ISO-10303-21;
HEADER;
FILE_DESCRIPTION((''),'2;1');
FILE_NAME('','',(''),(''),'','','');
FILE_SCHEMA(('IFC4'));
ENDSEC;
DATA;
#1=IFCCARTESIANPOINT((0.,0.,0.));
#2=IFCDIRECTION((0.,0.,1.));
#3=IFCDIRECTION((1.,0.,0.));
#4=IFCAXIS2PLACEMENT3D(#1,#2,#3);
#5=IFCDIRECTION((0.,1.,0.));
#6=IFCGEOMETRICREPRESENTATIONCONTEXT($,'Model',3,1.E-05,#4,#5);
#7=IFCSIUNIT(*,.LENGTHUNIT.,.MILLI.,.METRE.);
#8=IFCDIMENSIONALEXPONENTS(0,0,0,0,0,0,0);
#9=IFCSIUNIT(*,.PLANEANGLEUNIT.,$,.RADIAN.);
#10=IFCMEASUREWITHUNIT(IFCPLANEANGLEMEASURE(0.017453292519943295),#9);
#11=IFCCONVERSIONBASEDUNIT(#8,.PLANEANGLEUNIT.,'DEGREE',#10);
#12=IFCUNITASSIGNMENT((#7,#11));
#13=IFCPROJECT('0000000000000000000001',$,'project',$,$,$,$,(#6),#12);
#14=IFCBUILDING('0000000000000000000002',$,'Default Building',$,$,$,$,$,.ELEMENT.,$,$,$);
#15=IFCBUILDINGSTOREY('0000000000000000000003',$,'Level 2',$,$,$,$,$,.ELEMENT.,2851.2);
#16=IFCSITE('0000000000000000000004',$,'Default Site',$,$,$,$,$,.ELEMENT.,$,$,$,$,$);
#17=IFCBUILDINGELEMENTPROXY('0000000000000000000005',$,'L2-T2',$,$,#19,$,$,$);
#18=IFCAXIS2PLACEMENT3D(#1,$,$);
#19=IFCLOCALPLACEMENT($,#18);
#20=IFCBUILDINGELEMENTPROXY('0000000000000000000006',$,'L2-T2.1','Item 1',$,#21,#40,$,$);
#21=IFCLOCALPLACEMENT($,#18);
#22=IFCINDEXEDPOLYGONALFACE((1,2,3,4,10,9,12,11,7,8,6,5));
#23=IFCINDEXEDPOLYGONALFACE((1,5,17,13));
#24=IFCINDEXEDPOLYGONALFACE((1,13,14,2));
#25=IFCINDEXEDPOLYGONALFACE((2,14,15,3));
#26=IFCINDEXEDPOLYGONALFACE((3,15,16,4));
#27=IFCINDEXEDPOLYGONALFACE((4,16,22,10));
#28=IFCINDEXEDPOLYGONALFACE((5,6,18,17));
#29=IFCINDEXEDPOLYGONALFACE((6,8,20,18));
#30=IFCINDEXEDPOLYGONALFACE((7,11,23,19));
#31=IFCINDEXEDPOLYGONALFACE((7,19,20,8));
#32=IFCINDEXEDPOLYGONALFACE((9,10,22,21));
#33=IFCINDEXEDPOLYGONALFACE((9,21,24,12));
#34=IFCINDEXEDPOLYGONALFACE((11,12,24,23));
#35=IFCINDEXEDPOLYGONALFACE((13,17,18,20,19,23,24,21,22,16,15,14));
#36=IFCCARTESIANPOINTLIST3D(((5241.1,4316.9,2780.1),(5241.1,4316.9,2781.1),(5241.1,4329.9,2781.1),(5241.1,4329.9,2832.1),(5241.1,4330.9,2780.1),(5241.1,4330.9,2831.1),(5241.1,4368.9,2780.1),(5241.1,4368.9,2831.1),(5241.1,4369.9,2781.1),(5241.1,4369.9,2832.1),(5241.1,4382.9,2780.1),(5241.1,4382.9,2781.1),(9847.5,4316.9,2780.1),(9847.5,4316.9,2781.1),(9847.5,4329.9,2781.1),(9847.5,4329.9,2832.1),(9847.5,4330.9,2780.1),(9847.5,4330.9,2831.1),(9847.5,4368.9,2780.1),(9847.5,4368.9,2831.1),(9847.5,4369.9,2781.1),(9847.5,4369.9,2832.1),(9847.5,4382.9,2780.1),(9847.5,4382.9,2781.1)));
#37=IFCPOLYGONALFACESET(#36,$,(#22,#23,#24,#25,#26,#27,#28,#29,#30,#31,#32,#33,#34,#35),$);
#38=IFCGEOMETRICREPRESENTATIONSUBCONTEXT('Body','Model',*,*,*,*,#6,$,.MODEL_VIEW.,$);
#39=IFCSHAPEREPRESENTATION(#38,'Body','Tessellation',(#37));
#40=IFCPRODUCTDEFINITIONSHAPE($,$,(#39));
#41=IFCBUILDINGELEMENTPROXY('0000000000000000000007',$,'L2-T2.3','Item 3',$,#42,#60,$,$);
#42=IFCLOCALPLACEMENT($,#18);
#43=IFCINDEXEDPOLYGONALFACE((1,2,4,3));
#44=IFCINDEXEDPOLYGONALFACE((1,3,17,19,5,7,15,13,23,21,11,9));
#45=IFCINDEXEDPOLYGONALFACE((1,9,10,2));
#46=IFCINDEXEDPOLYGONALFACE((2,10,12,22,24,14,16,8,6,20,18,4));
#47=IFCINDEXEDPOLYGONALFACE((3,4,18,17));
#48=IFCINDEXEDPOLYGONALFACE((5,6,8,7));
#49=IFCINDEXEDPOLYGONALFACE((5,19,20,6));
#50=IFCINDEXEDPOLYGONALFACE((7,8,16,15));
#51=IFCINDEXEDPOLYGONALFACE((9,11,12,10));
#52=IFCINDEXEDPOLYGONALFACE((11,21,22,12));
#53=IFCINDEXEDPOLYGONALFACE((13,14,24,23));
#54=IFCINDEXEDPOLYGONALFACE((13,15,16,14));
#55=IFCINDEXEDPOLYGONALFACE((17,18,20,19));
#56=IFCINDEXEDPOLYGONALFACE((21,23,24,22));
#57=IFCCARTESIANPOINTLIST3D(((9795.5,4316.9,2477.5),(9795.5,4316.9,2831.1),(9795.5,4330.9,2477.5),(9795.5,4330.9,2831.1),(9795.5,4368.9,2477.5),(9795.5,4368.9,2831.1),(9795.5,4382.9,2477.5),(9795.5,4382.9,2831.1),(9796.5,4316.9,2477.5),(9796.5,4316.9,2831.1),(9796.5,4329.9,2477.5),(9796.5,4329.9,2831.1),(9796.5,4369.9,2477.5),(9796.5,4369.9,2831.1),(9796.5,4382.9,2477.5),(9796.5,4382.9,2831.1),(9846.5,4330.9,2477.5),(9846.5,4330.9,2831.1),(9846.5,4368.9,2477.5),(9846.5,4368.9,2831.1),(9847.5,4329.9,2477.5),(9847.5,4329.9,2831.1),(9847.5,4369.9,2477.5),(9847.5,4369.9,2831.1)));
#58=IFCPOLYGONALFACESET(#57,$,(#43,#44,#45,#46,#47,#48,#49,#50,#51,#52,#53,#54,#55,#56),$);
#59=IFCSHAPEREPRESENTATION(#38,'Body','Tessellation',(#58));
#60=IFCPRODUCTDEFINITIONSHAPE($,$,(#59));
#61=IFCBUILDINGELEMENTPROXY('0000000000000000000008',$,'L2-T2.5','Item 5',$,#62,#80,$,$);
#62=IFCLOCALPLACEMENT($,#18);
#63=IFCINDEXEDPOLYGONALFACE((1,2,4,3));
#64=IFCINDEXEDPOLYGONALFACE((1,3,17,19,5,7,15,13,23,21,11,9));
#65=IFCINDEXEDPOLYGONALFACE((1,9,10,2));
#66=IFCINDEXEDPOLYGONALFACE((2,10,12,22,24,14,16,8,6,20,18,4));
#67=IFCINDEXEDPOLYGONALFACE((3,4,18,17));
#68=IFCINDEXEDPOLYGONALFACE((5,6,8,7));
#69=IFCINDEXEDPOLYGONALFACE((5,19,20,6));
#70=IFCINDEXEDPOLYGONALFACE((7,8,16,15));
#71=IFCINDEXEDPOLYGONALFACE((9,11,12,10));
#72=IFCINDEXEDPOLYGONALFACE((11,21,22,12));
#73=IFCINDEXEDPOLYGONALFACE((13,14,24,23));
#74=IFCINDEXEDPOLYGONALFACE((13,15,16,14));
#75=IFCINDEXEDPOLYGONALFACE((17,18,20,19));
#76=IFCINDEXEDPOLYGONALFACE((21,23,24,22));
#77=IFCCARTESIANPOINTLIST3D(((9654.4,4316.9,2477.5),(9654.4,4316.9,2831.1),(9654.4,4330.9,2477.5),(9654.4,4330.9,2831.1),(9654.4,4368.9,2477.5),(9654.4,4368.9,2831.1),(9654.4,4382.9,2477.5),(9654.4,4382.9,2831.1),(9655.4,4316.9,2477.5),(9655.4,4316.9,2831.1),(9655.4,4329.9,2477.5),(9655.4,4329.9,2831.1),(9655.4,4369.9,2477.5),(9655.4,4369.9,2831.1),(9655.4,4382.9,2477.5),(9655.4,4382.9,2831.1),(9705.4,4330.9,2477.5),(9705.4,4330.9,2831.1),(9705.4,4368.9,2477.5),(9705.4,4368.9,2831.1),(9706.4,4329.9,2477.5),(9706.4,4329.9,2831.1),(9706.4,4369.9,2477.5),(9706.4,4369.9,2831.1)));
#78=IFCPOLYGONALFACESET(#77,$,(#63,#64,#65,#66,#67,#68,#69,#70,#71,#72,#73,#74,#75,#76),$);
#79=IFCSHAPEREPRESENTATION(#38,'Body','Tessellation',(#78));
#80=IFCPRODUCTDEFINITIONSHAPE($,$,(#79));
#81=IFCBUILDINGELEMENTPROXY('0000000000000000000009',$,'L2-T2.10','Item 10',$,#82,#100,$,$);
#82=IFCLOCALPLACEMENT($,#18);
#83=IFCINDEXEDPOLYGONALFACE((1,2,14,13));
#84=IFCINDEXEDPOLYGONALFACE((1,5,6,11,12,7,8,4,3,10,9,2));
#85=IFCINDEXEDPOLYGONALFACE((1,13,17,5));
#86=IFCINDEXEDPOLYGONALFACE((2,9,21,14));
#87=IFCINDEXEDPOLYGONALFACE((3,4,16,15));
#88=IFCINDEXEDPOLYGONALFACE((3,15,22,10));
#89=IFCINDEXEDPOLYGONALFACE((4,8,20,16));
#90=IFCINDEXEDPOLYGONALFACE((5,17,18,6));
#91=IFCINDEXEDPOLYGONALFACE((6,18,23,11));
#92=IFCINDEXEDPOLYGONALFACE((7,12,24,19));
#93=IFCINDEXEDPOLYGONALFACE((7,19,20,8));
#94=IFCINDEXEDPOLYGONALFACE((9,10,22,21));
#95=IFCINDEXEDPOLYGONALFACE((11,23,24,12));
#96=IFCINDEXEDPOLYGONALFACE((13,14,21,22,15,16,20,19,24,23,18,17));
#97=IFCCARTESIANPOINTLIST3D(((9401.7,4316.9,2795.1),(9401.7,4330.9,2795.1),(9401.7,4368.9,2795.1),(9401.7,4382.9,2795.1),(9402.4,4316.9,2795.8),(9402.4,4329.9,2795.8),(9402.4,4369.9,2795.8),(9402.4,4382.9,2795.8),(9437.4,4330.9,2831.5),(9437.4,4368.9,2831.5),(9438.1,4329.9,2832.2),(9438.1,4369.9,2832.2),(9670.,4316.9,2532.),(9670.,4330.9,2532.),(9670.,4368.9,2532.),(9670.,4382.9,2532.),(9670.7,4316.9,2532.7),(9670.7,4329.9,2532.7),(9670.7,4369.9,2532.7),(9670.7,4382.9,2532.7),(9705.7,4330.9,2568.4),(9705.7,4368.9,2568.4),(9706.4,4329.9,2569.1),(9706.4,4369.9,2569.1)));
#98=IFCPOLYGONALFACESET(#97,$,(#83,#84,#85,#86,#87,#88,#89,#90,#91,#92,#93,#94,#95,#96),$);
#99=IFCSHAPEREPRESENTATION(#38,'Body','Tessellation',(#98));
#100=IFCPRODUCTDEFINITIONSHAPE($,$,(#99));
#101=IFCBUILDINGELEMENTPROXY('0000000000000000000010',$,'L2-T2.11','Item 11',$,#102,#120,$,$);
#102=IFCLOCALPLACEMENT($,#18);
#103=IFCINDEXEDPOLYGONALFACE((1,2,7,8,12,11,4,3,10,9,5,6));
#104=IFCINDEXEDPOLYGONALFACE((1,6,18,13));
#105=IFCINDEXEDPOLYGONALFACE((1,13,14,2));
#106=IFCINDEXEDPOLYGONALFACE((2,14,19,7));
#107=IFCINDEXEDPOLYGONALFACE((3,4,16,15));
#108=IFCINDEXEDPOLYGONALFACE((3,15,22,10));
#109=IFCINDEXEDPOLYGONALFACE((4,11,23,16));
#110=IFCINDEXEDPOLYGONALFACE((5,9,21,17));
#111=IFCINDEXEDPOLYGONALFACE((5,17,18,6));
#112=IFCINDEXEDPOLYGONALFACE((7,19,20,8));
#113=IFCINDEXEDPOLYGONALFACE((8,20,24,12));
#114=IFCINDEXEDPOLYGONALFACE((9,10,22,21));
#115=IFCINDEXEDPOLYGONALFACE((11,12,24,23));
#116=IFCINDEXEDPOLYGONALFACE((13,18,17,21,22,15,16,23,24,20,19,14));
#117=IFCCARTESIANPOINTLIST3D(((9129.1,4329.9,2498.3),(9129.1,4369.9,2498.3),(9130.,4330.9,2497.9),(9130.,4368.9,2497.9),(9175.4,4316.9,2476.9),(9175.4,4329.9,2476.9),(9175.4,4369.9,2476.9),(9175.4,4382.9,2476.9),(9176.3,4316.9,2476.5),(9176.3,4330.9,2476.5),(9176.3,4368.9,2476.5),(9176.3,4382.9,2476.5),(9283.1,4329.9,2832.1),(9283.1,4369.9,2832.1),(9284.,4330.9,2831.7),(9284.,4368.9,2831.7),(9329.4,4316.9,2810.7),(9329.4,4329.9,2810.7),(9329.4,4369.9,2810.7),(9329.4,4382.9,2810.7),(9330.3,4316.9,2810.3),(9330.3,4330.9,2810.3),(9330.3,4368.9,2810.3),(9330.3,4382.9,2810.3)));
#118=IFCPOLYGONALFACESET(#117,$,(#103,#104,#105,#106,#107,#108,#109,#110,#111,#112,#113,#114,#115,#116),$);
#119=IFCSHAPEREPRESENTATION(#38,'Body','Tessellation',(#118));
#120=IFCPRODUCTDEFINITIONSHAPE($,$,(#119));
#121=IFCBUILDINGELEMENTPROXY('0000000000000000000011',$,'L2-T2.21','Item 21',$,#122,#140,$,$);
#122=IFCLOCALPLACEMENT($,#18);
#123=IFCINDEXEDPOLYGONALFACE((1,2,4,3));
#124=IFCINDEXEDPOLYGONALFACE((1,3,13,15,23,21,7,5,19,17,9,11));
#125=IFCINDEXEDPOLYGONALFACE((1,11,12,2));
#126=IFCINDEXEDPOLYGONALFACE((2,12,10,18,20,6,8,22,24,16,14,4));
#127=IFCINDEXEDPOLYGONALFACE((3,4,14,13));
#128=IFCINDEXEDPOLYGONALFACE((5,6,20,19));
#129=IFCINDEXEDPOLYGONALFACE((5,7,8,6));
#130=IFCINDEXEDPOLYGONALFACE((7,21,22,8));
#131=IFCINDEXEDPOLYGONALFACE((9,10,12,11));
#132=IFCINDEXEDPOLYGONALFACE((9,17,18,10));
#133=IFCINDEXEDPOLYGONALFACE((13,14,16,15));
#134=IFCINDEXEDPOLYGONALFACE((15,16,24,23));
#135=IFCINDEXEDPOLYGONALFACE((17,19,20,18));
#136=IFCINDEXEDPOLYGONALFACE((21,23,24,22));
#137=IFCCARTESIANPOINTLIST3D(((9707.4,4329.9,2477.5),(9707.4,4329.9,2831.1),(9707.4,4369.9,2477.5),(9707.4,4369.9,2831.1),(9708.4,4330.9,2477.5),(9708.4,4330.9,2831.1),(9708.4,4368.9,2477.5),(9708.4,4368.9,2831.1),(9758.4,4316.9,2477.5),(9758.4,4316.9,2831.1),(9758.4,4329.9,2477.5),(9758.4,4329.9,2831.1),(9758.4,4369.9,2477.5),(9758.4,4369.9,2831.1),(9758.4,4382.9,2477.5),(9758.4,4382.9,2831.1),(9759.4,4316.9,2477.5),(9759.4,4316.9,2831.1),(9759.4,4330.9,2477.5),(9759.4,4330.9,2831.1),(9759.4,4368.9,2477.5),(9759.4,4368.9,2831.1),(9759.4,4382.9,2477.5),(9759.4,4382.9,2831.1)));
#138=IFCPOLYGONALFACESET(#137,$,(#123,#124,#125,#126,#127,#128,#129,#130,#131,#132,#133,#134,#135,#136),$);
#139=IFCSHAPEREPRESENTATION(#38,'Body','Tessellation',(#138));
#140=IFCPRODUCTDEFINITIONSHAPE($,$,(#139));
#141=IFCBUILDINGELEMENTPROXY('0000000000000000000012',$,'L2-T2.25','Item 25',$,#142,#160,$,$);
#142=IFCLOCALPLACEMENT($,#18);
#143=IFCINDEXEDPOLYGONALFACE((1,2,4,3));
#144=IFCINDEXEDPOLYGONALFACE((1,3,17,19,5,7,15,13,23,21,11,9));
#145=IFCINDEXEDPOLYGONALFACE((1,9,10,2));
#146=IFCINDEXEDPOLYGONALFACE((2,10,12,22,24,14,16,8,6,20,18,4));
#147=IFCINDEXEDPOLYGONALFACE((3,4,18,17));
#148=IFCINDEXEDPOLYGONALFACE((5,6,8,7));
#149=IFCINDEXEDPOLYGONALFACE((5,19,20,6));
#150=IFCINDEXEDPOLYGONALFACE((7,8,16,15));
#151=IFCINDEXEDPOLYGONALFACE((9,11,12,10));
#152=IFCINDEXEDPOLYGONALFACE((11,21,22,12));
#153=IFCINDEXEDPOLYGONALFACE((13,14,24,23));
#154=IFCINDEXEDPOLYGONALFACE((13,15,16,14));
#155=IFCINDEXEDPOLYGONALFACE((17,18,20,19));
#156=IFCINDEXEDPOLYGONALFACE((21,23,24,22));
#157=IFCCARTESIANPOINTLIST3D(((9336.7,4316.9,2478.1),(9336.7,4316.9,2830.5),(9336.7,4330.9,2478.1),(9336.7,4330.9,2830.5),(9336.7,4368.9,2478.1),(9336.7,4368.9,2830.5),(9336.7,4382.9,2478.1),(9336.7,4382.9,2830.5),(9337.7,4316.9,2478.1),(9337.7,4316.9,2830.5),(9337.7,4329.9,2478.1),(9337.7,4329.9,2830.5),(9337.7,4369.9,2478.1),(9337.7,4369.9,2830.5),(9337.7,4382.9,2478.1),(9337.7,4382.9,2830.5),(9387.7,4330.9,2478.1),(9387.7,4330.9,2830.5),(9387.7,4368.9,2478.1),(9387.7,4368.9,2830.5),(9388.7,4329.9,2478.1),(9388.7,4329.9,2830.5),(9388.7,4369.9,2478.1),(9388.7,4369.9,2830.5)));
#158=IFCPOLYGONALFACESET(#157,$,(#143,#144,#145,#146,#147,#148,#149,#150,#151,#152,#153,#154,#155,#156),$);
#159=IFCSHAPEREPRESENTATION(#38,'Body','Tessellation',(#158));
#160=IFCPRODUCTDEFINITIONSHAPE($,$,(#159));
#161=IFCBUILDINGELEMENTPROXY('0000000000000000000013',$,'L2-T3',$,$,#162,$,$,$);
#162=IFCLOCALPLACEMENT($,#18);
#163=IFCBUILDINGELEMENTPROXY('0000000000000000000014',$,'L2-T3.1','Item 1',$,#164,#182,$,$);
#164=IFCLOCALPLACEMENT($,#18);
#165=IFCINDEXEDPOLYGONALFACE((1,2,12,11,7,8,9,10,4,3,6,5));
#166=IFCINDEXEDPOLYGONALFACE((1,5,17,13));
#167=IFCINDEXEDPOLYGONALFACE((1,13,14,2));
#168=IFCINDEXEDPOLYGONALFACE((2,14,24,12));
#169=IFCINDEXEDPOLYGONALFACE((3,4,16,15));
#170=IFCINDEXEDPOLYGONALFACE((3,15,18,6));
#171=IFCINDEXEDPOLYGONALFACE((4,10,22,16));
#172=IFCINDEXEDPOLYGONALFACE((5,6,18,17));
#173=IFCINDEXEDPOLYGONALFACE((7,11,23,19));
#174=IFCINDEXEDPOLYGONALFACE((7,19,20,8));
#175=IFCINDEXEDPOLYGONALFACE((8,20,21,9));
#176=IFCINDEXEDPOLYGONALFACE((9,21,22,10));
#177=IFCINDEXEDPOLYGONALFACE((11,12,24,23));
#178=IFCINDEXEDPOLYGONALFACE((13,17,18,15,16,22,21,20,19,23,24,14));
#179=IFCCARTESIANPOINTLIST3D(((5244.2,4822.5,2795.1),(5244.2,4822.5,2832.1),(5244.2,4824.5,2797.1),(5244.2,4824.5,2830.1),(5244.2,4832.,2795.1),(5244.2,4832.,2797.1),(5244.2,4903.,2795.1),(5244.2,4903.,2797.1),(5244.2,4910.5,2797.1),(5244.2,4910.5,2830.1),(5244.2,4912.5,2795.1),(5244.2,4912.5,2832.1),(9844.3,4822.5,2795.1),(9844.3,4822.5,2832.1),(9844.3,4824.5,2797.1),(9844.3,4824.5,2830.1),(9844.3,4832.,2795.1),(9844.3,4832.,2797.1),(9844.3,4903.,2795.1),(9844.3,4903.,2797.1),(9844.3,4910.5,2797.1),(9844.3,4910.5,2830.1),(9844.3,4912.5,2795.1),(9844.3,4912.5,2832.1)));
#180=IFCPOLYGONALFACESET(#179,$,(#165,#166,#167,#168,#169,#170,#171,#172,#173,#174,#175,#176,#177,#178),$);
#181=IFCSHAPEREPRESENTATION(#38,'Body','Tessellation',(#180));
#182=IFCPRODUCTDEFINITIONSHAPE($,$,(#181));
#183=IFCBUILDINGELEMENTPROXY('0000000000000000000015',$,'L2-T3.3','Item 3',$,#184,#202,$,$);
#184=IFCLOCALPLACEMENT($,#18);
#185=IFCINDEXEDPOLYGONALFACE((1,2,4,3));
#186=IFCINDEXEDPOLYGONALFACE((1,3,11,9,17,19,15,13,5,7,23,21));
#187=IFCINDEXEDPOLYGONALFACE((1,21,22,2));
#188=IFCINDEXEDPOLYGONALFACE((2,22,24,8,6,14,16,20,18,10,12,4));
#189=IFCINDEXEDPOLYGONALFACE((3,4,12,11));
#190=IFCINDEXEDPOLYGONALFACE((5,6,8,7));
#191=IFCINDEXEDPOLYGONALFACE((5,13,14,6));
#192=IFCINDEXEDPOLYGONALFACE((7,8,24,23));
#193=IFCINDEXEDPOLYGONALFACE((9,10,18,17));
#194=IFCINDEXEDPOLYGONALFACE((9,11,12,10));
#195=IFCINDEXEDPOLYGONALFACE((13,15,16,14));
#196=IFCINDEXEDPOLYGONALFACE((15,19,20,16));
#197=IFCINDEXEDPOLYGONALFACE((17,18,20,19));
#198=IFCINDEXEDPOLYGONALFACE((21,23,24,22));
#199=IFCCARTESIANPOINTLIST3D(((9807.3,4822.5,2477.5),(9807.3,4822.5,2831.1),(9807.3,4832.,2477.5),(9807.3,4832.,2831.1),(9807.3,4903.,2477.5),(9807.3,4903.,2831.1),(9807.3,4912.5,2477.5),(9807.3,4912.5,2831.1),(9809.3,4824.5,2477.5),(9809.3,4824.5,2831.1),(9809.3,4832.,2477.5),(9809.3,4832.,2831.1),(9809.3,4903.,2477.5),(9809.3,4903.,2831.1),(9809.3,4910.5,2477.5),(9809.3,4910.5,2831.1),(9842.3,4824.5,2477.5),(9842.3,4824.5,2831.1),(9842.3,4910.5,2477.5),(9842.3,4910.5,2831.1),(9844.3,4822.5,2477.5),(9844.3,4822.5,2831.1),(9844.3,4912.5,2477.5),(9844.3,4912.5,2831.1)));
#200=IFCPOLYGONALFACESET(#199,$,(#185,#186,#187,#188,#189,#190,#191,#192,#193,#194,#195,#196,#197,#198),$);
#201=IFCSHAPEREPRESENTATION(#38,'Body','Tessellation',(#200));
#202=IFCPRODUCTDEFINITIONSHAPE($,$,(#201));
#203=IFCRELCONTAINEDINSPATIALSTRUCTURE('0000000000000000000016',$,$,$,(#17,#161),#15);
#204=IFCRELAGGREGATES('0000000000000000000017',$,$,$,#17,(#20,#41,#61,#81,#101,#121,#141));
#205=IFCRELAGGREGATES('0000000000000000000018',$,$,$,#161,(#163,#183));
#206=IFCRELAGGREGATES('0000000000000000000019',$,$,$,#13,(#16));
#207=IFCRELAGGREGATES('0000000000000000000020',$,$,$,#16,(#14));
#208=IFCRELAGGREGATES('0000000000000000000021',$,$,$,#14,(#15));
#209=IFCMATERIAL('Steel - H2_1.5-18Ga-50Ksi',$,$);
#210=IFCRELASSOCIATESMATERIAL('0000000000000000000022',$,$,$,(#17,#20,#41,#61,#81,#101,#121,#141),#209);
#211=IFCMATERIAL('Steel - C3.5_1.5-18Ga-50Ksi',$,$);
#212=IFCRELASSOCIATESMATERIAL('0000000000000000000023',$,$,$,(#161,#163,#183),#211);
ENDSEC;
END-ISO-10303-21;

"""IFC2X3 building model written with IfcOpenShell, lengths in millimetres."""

from ifc_helpers import new_model, entity, si_unit, converted_unit, direction, frame, origin, origin_with_axes, origin_2d_with_axis, place, context, subcontext, project, spatial, polyline, c_section, outline, extrude, material, element, aggregate, save


model = new_model("IFC2X3")

# Units and contexts
model_context = context("Model", 3, precision=1e-05, world=origin_with_axes(), true_north=direction((0.0, 1.0, 0.0)))
body_context = subcontext(model_context, "Body", "Model", "MODEL_VIEW")
ifc_project = project(units=[si_unit("LENGTHUNIT", "METRE", prefix="MILLI"), converted_unit("PLANEANGLEUNIT", "DEGREE", entity("IfcPlaneAngleMeasure", 0.017453292519943295), si_unit("PLANEANGLEUNIT", "RADIAN"), dimensions=[0, 0, 0, 0, 0, 0, 0])], contexts=[model_context])

# Site, building, storey
site = spatial("IfcSite", under=ifc_project, Name="Default Site", CompositionType="ELEMENT")
building = spatial("IfcBuilding", under=site, Name="Default Building", CompositionType="ELEMENT")
storey = spatial("IfcBuildingStorey", under=building, Name="Level 2", CompositionType="ELEMENT", Elevation=2851.2)

# Building element proxies
ifc_material_1 = material(Name="Steel - H2_1.5-18Ga-50Ksi")
proxy_1 = element("IfcBuildingElementProxy", 1, inside=storey, material=ifc_material_1, Name="L2-T2")
proxy_2_placement = place(None, frame((9847.5, 4382.9, 2780.1), z_axis=(-1.0, 0.0, 0.0), x_axis=(0.0, -40.0, 0.0)))
proxy_2 = element("IfcBuildingElementProxy", 2, at=proxy_2_placement, material=ifc_material_1, Name="L2-T2.1", Description="Item 1", context=body_context, shape_type="SweptSolid", body=[
    extrude(outline(polyline([(0.0, 0.0), (14.0, 0.0), (14.0, 51.0), (52.0, 51.0), (52.0, 0.0), (66.0, 0.0), (66.0, 1.0), (53.0, 1.0), (53.0, 52.0), (13.0, 52.0), (13.0, 1.0), (0.0, 1.0), (0.0, 0.0)])), origin(), (0.0, 0.0, 1.0), 4606.4),
])
proxy_3_placement = place(None, frame((9795.5, 4382.9, 2477.5), z_axis=(0.0, 0.0, 1.0), x_axis=(0.0, -40.0, 0.0)))
proxy_3 = element("IfcBuildingElementProxy", 3, at=proxy_3_placement, material=ifc_material_1, Name="L2-T2.3", Description="Item 3", context=body_context, shape_type="SweptSolid", body=[
    extrude(outline(polyline([(0.0, 0.0), (14.0, 0.0), (14.0, 51.0), (52.0, 51.0), (52.0, 0.0), (66.0, 0.0), (66.0, 1.0), (53.0, 1.0), (53.0, 52.0), (13.0, 52.0), (13.0, 1.0), (0.0, 1.0), (0.0, 0.0)])), origin(), (0.0, 0.0, 1.0), 353.6),
])
proxy_4_placement = place(None, frame((9654.4, 4382.9, 2477.5), z_axis=(0.0, 0.0, 1.0), x_axis=(0.0, -40.0, 0.0)))
proxy_4 = element("IfcBuildingElementProxy", 4, at=proxy_4_placement, material=ifc_material_1, Name="L2-T2.5", Description="Item 5", context=body_context, shape_type="SweptSolid", body=[
    extrude(outline(polyline([(0.0, 0.0), (14.0, 0.0), (14.0, 51.0), (52.0, 51.0), (52.0, 0.0), (66.0, 0.0), (66.0, 1.0), (53.0, 1.0), (53.0, 52.0), (13.0, 52.0), (13.0, 1.0), (0.0, 1.0), (0.0, 0.0)])), origin(), (0.0, 0.0, 1.0), 353.6),
])
proxy_5_placement = place(None, frame((9670.0, 4382.9, 2532.0), z_axis=(-0.714, 0.0, 0.7), x_axis=(0.0, -40.0, 0.0)))
proxy_5 = element("IfcBuildingElementProxy", 5, at=proxy_5_placement, material=ifc_material_1, Name="L2-T2.10", Description="Item 10", context=body_context, shape_type="SweptSolid", body=[
    extrude(outline(polyline([(0.0, 0.0), (14.0, 0.0), (14.0, 51.0), (52.0, 51.0), (52.0, 0.0), (66.0, 0.0), (66.0, 1.0), (53.0, 1.0), (53.0, 52.0), (13.0, 52.0), (13.0, 1.0), (0.0, 1.0), (0.0, 0.0)])), origin(), (0.0, 0.0, 1.0), 375.8),
])
proxy_6_placement = place(None, frame((9330.3, 4382.9, 2810.3), z_axis=(-0.419, 0.0, -0.908), x_axis=(0.0, -40.0, 0.0)))
proxy_6 = element("IfcBuildingElementProxy", 6, at=proxy_6_placement, material=ifc_material_1, Name="L2-T2.11", Description="Item 11", context=body_context, shape_type="SweptSolid", body=[
    extrude(outline(polyline([(0.0, 0.0), (14.0, 0.0), (14.0, 51.0), (52.0, 51.0), (52.0, 0.0), (66.0, 0.0), (66.0, 1.0), (53.0, 1.0), (53.0, 52.0), (13.0, 52.0), (13.0, 1.0), (0.0, 1.0), (0.0, 0.0)])), origin(), (0.0, 0.0, 1.0), 367.6),
])
proxy_7_placement = place(None, frame((9759.4, 4382.9, 2831.1), z_axis=(0.0, 0.0, -1.0), x_axis=(0.0, -40.0, 0.0)))
proxy_7 = element("IfcBuildingElementProxy", 7, at=proxy_7_placement, material=ifc_material_1, Name="L2-T2.21", Description="Item 21", context=body_context, shape_type="SweptSolid", body=[
    extrude(outline(polyline([(0.0, 0.0), (14.0, 0.0), (14.0, 51.0), (52.0, 51.0), (52.0, 0.0), (66.0, 0.0), (66.0, 1.0), (53.0, 1.0), (53.0, 52.0), (13.0, 52.0), (13.0, 1.0), (0.0, 1.0), (0.0, 0.0)])), origin(), (0.0, 0.0, 1.0), 353.6),
])
proxy_8_placement = place(None, frame((9336.7, 4382.9, 2478.1), z_axis=(0.0, 0.0, 1.0), x_axis=(0.0, -40.0, 0.0)))
proxy_8 = element("IfcBuildingElementProxy", 8, at=proxy_8_placement, material=ifc_material_1, Name="L2-T2.25", Description="Item 25", context=body_context, shape_type="SweptSolid", body=[
    extrude(outline(polyline([(0.0, 0.0), (14.0, 0.0), (14.0, 51.0), (52.0, 51.0), (52.0, 0.0), (66.0, 0.0), (66.0, 1.0), (53.0, 1.0), (53.0, 52.0), (13.0, 52.0), (13.0, 1.0), (0.0, 1.0), (0.0, 0.0)])), origin(), (0.0, 0.0, 1.0), 352.4),
])
aggregate(proxy_1, [proxy_2, proxy_3, proxy_4, proxy_5, proxy_6, proxy_7, proxy_8])
ifc_material_2 = material(Name="Steel - C3.5_1.5-18Ga-50Ksi")
proxy_9 = element("IfcBuildingElementProxy", 9, inside=storey, material=ifc_material_2, Name="L2-T3")
proxy_10_placement = place(None, frame((9844.3, 4867.5, 2813.6), z_axis=(-1.0, 0.0, 0.0), x_axis=(0.0, 0.0, -37.0)))
proxy_10 = element("IfcBuildingElementProxy", 10, at=proxy_10_placement, material=ifc_material_2, Name="L2-T3.1", Description="Item 1", context=body_context, shape_type="SweptSolid", body=[
    extrude(c_section(Depth=90.0, Width=37.0, WallThickness=2.0, Girth=9.5, at=origin_2d_with_axis()), origin(), (0.0, 0.0, 1.0), 4600.1),
])
proxy_11_placement = place(None, frame((9825.8, 4867.5, 2477.5), z_axis=(0.0, 0.0, 1.0), x_axis=(-37.0, 0.0, 0.0)))
proxy_11 = element("IfcBuildingElementProxy", 11, at=proxy_11_placement, material=ifc_material_2, Name="L2-T3.3", Description="Item 3", context=body_context, shape_type="SweptSolid", body=[
    extrude(c_section(Depth=90.0, Width=37.0, WallThickness=2.0, Girth=9.5, at=origin_2d_with_axis()), origin(), (0.0, 0.0, 1.0), 353.6),
])
aggregate(proxy_9, [proxy_10, proxy_11])

save(model, "model.ifc")
